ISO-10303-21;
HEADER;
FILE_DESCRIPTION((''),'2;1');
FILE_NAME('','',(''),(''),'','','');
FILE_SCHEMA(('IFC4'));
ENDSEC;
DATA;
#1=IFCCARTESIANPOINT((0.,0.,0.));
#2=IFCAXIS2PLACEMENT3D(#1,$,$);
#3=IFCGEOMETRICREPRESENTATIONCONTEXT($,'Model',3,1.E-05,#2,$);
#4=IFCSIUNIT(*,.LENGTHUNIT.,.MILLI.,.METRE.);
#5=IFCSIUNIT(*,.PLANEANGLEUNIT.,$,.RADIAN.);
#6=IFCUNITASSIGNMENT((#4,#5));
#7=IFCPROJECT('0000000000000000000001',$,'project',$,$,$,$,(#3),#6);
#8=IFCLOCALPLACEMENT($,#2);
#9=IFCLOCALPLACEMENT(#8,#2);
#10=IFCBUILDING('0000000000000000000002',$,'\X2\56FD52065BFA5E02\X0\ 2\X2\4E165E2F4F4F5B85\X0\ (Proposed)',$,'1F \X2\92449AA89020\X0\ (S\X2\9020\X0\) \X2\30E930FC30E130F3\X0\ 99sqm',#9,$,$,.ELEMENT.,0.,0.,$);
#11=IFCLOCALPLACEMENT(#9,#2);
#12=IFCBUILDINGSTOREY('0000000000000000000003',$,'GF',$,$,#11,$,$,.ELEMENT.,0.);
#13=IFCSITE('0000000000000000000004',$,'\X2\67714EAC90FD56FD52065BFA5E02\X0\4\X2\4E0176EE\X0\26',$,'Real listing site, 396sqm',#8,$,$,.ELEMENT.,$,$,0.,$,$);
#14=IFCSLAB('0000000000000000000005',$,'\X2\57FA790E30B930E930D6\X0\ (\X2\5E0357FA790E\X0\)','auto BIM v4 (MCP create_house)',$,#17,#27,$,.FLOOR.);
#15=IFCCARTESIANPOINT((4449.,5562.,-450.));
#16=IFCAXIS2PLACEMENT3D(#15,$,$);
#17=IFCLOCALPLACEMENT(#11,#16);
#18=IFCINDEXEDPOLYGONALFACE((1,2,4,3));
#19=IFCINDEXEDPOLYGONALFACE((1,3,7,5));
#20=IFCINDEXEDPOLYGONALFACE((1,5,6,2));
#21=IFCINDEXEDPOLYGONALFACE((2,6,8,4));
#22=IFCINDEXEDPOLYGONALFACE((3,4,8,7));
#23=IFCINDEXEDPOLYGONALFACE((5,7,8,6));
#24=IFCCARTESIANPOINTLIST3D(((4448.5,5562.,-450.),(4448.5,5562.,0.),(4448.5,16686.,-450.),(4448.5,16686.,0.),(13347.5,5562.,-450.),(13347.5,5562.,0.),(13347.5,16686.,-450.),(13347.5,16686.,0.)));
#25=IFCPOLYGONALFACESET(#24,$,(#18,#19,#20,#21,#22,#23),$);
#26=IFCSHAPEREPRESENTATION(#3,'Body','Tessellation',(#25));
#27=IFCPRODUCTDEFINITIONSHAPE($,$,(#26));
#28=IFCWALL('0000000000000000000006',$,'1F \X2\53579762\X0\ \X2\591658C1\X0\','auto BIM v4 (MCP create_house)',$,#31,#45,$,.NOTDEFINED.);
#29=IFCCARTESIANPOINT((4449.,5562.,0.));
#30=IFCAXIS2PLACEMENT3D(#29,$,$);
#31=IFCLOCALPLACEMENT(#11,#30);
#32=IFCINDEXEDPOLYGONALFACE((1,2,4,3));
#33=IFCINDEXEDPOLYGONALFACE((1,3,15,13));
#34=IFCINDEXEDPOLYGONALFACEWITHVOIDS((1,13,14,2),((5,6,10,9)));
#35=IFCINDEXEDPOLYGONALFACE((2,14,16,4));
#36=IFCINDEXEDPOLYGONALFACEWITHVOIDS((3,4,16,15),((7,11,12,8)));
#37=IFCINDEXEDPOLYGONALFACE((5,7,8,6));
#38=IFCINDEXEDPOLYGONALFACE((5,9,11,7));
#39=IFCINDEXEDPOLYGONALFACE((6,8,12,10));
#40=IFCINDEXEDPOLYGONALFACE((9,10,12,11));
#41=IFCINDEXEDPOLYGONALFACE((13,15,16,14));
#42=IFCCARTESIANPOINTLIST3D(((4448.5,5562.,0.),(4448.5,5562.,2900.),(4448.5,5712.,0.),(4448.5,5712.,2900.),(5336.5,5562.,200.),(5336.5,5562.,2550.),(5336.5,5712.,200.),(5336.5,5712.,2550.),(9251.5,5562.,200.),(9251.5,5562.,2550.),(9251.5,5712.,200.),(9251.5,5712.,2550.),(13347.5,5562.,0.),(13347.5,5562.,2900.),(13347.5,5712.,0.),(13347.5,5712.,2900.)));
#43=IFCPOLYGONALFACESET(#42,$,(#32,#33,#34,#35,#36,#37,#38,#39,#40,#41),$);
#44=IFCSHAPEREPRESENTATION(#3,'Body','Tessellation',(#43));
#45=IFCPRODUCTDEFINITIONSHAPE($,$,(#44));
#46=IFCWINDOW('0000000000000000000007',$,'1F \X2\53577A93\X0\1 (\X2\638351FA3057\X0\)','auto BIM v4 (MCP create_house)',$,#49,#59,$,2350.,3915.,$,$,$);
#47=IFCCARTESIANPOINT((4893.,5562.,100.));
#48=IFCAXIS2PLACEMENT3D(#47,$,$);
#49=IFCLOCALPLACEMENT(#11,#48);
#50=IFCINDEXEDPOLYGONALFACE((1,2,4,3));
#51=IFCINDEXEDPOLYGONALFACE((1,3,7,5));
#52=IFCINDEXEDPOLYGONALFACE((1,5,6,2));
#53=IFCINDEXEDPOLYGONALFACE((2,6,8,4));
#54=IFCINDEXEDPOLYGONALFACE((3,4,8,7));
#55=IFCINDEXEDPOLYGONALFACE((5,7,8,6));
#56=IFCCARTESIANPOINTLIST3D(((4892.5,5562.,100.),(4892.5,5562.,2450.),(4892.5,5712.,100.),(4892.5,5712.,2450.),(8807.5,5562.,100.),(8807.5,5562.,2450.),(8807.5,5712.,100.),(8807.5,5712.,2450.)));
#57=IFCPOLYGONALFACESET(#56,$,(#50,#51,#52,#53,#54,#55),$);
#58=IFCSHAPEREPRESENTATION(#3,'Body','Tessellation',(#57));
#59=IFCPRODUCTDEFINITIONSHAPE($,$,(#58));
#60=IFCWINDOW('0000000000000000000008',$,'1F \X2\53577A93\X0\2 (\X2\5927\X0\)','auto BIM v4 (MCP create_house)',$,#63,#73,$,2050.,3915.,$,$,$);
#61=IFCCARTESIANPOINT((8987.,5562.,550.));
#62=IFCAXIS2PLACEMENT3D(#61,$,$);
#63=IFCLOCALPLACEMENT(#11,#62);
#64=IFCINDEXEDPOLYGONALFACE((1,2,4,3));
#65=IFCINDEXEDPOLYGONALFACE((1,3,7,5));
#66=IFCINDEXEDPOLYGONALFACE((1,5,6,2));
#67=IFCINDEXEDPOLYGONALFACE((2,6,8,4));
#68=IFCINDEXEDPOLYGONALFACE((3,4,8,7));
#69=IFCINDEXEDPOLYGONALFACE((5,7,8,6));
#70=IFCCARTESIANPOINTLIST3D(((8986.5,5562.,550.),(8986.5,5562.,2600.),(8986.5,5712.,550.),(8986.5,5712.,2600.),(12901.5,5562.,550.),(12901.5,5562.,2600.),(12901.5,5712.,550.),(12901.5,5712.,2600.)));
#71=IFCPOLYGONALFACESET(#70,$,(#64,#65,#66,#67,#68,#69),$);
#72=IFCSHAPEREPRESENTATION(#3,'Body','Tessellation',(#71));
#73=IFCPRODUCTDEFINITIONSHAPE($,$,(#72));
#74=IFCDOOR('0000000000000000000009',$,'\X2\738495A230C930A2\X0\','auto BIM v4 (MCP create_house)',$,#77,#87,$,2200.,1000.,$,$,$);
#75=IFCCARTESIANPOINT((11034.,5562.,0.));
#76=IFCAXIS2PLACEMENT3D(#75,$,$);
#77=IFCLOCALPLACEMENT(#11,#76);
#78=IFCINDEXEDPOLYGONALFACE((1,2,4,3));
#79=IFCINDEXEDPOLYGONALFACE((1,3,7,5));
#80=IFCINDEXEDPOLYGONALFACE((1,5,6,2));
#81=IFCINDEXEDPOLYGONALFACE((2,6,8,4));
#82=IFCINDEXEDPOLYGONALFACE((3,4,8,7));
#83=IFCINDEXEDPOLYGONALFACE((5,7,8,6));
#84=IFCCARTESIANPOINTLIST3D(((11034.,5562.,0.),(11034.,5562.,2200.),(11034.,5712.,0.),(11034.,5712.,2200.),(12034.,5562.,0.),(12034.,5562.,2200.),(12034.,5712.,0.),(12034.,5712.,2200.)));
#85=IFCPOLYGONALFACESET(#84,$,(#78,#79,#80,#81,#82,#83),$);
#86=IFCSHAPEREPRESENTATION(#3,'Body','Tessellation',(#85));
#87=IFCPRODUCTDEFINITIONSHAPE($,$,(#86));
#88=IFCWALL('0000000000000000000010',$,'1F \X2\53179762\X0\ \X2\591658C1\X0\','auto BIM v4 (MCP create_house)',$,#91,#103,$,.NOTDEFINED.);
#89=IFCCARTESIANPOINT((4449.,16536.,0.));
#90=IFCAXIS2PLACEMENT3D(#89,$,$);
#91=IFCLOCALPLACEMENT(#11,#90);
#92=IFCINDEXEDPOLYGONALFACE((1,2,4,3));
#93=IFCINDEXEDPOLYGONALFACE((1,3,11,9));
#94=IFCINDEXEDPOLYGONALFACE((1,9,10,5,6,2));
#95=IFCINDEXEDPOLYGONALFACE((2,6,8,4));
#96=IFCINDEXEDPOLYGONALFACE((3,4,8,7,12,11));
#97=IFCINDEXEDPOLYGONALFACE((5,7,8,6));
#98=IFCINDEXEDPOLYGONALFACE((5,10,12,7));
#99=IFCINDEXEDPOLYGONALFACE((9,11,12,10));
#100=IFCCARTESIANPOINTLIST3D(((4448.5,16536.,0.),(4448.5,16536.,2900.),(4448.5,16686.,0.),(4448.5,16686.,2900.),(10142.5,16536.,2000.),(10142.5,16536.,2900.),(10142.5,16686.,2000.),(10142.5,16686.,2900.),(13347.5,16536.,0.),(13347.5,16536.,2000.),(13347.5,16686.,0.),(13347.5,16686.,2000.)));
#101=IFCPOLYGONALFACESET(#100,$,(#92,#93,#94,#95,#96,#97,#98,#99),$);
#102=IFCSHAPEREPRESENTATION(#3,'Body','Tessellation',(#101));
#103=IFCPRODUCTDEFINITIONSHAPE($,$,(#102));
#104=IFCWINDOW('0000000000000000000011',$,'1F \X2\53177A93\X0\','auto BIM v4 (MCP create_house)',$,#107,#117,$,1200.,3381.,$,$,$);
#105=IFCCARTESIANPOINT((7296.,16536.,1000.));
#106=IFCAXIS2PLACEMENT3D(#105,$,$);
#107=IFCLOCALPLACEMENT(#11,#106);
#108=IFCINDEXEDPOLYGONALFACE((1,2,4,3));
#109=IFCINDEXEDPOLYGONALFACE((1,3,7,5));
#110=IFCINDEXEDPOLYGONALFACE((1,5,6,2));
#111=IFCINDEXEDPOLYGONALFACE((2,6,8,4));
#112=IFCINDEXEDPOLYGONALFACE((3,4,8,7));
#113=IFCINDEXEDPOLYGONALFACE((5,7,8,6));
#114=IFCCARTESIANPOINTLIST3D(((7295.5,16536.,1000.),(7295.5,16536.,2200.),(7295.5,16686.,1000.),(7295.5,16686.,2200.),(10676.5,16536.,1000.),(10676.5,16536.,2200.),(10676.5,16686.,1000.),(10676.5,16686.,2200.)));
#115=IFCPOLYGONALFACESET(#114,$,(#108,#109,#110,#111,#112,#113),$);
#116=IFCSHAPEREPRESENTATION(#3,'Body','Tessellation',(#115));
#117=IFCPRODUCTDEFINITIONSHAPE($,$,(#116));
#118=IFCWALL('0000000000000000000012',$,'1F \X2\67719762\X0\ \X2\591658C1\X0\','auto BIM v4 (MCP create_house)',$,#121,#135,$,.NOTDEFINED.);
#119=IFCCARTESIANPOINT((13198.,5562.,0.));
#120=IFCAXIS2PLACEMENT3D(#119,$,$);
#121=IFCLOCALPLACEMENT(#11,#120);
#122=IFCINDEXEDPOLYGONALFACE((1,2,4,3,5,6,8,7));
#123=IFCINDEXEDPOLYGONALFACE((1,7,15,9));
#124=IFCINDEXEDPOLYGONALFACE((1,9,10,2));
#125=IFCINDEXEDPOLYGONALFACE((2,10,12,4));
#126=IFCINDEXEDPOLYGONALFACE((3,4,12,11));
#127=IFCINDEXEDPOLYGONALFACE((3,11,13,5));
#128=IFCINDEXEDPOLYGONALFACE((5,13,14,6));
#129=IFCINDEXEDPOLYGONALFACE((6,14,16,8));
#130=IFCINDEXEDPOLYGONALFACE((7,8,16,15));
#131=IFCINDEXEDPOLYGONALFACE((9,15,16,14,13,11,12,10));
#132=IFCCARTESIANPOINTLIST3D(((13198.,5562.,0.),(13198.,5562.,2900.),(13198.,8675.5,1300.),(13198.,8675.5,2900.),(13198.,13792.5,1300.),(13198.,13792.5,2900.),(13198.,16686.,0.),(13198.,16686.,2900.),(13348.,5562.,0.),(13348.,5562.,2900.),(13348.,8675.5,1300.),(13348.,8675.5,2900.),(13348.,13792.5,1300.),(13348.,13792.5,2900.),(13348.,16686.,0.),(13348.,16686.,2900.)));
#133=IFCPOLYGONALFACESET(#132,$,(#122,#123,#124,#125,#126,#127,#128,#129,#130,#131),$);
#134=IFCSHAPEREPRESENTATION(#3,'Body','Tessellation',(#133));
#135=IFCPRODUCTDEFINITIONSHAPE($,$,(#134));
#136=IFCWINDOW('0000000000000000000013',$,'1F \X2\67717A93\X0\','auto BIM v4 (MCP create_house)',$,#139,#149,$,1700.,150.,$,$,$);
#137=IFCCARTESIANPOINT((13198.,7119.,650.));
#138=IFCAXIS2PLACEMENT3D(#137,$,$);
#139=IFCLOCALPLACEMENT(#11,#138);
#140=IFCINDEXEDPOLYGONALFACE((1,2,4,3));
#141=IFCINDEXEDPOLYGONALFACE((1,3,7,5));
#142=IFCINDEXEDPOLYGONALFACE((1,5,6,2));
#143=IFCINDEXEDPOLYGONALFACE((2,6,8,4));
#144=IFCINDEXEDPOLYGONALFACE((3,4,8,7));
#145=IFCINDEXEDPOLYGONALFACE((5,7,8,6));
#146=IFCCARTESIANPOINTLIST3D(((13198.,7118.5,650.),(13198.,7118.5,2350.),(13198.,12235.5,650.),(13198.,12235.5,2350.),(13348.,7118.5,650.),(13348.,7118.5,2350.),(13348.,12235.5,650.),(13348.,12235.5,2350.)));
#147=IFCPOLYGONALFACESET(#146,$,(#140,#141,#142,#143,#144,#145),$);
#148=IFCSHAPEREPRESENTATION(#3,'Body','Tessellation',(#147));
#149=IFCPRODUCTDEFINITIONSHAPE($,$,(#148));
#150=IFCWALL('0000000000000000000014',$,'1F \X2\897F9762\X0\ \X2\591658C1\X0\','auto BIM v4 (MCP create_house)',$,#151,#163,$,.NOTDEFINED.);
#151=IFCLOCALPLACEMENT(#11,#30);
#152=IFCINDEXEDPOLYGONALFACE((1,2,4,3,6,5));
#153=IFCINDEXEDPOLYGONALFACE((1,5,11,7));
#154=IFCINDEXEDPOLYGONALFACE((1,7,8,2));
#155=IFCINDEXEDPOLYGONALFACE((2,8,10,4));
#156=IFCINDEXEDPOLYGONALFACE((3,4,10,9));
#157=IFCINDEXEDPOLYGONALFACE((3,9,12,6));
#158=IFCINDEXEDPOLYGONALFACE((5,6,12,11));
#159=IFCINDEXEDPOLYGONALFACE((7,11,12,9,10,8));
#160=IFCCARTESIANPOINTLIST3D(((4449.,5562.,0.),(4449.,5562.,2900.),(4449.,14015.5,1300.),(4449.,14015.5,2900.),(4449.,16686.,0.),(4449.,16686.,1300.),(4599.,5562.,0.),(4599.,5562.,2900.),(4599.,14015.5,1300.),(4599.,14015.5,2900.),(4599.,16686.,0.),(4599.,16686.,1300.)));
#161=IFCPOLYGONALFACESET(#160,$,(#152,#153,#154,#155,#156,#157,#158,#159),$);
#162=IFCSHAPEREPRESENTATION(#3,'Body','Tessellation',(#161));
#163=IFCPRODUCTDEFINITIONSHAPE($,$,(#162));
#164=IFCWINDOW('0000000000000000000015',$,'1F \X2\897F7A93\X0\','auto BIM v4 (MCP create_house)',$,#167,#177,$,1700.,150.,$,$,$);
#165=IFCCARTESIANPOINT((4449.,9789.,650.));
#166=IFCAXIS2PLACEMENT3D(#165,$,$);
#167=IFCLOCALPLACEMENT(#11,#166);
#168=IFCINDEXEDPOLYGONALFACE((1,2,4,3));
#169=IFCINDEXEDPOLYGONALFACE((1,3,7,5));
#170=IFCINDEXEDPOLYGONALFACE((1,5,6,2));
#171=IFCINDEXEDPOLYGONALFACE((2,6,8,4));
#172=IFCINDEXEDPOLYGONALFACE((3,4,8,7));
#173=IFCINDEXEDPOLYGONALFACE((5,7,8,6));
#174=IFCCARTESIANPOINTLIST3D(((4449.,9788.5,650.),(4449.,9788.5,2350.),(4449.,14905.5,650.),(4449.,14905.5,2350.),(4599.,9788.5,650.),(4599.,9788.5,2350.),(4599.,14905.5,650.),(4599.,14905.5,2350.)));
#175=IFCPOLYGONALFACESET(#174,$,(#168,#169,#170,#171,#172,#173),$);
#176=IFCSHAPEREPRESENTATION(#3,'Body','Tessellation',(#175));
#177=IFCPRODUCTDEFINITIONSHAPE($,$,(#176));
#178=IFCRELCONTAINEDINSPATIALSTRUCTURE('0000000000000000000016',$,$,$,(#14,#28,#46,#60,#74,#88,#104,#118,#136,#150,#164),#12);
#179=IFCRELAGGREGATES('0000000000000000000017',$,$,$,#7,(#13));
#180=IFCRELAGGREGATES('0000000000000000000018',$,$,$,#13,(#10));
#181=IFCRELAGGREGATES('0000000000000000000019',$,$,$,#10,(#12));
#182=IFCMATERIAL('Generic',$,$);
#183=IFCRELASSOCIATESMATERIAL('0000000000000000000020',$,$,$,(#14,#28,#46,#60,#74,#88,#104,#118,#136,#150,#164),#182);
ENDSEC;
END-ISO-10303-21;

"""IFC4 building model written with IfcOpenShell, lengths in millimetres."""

from ifc_helpers import new_model, si_unit, frame, frame_2d, origin, place, context, project, spatial, rectangle, extrude, material, element, fill, save


model = new_model("IFC4")

# Units and contexts
model_context = context("Model", 3, precision=1e-05, world=origin())
ifc_project = project(units=[si_unit("LENGTHUNIT", "METRE", prefix="MILLI"), si_unit("PLANEANGLEUNIT", "RADIAN")], contexts=[model_context])

# Site, building, storey
site_placement = place(None, origin())
site = spatial("IfcSite", under=ifc_project, at=site_placement, Name="東京都国分寺市4丁目26", ObjectType="Real listing site, 396sqm", CompositionType="ELEMENT", RefElevation=0.0)
building_placement = place(site_placement, origin())
building = spatial("IfcBuilding", under=site, at=building_placement, Name="国分寺市 2世帯住宅 (Proposed)", ObjectType="1F 鉄骨造 (S造) ラーメン 99sqm", CompositionType="ELEMENT", ElevationOfRefHeight=0.0, ElevationOfTerrain=0.0)
storey_placement = place(building_placement, origin())
storey = spatial("IfcBuildingStorey", under=building, at=storey_placement, Name="GF", CompositionType="ELEMENT", Elevation=0.0)

# Slab
ifc_material = material(Name="Generic")
slab_1_placement = place(storey_placement, frame((4449.0, 5562.0, -450.0)))
element("IfcSlab", 1, at=slab_1_placement, inside=storey, material=ifc_material, Name="基礎スラブ (布基礎)", Description="auto BIM v4 (MCP create_house)", PredefinedType="FLOOR", context=model_context, shape_type="SweptSolid", body=[
    extrude(rectangle(XDim=8899.0, YDim=11124.0, at=frame_2d((4449.0, 5562.0))), frame((4449.0, 5562.0, -450.0)), (0.0, 0.0, 1.0), 450.0),
])

# Wall, openings, windows, door
wall_1_placement = place(storey_placement, frame((4449.0, 5562.0, 0.0)))
wall_1 = element("IfcWall", 2, at=wall_1_placement, inside=storey, material=ifc_material, Name="1F 南面 外壁", Description="auto BIM v4 (MCP create_house)", PredefinedType="NOTDEFINED", context=model_context, shape_type="SweptSolid", body=[
    extrude(rectangle(XDim=8899.0, YDim=150.0, at=frame_2d((4449.0, 75.0))), frame((4449.0, 5562.0, 0.0)), (0.0, 0.0, 1.0), 2900.0),
])
opening_1_placement = place(storey_placement, frame((4893.0, 5562.0, 100.0)))
opening_1 = element("IfcOpeningElement", 3, at=opening_1_placement, cuts=wall_1, PredefinedType="NOTDEFINED", context=model_context, shape_type="SweptSolid", body=[
    extrude(rectangle(XDim=3915.0, YDim=150.0, at=frame_2d((1957.0, 75.0))), frame((4893.0, 5562.0, 100.0)), (0.0, 0.0, 1.0), 2350.0),
])
opening_2_placement = place(storey_placement, frame((8987.0, 5562.0, 550.0)))
opening_2 = element("IfcOpeningElement", 4, at=opening_2_placement, cuts=wall_1, PredefinedType="NOTDEFINED", context=model_context, shape_type="SweptSolid", body=[
    extrude(rectangle(XDim=3915.0, YDim=150.0, at=frame_2d((1957.0, 75.0))), frame((8987.0, 5562.0, 550.0)), (0.0, 0.0, 1.0), 2050.0),
])
opening_3_placement = place(storey_placement, frame((11034.0, 5562.0, 0.0)))
opening_3 = element("IfcOpeningElement", 5, at=opening_3_placement, cuts=wall_1, PredefinedType="NOTDEFINED", context=model_context, shape_type="SweptSolid", body=[
    extrude(rectangle(XDim=1000.0, YDim=150.0, at=frame_2d((500.0, 75.0))), frame((11034.0, 5562.0, 0.0)), (0.0, 0.0, 1.0), 2200.0),
])
window_1_placement = place(storey_placement, frame((4893.0, 5562.0, 100.0)))
window_1 = element("IfcWindow", 6, at=window_1_placement, inside=storey, material=ifc_material, Name="1F 南窓1 (掃出し)", Description="auto BIM v4 (MCP create_house)", OverallHeight=2350.0, OverallWidth=3915.0, context=model_context, shape_type="SweptSolid", body=[
    extrude(rectangle(XDim=3915.0, YDim=150.0, at=frame_2d((1957.0, 75.0))), frame((4893.0, 5562.0, 100.0)), (0.0, 0.0, 1.0), 2350.0),
])
fill(opening_1, window_1)
window_2_placement = place(storey_placement, frame((8987.0, 5562.0, 550.0)))
window_2 = element("IfcWindow", 7, at=window_2_placement, inside=storey, material=ifc_material, Name="1F 南窓2 (大)", Description="auto BIM v4 (MCP create_house)", OverallHeight=2050.0, OverallWidth=3915.0, context=model_context, shape_type="SweptSolid", body=[
    extrude(rectangle(XDim=3915.0, YDim=150.0, at=frame_2d((1957.0, 75.0))), frame((8987.0, 5562.0, 550.0)), (0.0, 0.0, 1.0), 2050.0),
])
fill(opening_2, window_2)
door_placement = place(storey_placement, frame((11034.0, 5562.0, 0.0)))
door = element("IfcDoor", 8, at=door_placement, inside=storey, material=ifc_material, Name="玄関ドア", Description="auto BIM v4 (MCP create_house)", OverallHeight=2200.0, OverallWidth=1000.0, context=model_context, shape_type="SweptSolid", body=[
    extrude(rectangle(XDim=1000.0, YDim=150.0, at=frame_2d((500.0, 75.0))), frame((11034.0, 5562.0, 0.0)), (0.0, 0.0, 1.0), 2200.0),
])
fill(opening_3, door)

# Walls, openings, windows
wall_2_placement = place(storey_placement, frame((4449.0, 16536.0, 0.0)))
wall_2 = element("IfcWall", 9, at=wall_2_placement, inside=storey, material=ifc_material, Name="1F 北面 外壁", Description="auto BIM v4 (MCP create_house)", PredefinedType="NOTDEFINED", context=model_context, shape_type="SweptSolid", body=[
    extrude(rectangle(XDim=8899.0, YDim=150.0, at=frame_2d((4449.0, 75.0))), frame((4449.0, 16536.0, 0.0)), (0.0, 0.0, 1.0), 2900.0),
])
opening_4_placement = place(storey_placement, frame((7296.0, 16536.0, 1000.0)))
opening_4 = element("IfcOpeningElement", 10, at=opening_4_placement, cuts=wall_2, PredefinedType="NOTDEFINED", context=model_context, shape_type="SweptSolid", body=[
    extrude(rectangle(XDim=3381.0, YDim=150.0, at=frame_2d((1690.0, 75.0))), frame((7296.0, 16536.0, 1000.0)), (0.0, 0.0, 1.0), 1200.0),
])
window_3_placement = place(storey_placement, frame((7296.0, 16536.0, 1000.0)))
window_3 = element("IfcWindow", 11, at=window_3_placement, inside=storey, material=ifc_material, Name="1F 北窓", Description="auto BIM v4 (MCP create_house)", OverallHeight=1200.0, OverallWidth=3381.0, context=model_context, shape_type="SweptSolid", body=[
    extrude(rectangle(XDim=3381.0, YDim=150.0, at=frame_2d((1690.0, 75.0))), frame((7296.0, 16536.0, 1000.0)), (0.0, 0.0, 1.0), 1200.0),
])
fill(opening_4, window_3)
wall_3_placement = place(storey_placement, frame((13198.0, 5562.0, 0.0)))
wall_3 = element("IfcWall", 12, at=wall_3_placement, inside=storey, material=ifc_material, Name="1F 東面 外壁", Description="auto BIM v4 (MCP create_house)", PredefinedType="NOTDEFINED", context=model_context, shape_type="SweptSolid", body=[
    extrude(rectangle(XDim=150.0, YDim=11124.0, at=frame_2d((75.0, 5562.0))), frame((13198.0, 5562.0, 0.0)), (0.0, 0.0, 1.0), 2900.0),
])
opening_5_placement = place(storey_placement, frame((13198.0, 7119.0, 650.0)))
opening_5 = element("IfcOpeningElement", 13, at=opening_5_placement, cuts=wall_3, PredefinedType="NOTDEFINED", context=model_context, shape_type="SweptSolid", body=[
    extrude(rectangle(XDim=150.0, YDim=5117.0, at=frame_2d((75.0, 2558.0))), frame((13198.0, 7119.0, 650.0)), (0.0, 0.0, 1.0), 1700.0),
])
window_4_placement = place(storey_placement, frame((13198.0, 7119.0, 650.0)))
window_4 = element("IfcWindow", 14, at=window_4_placement, inside=storey, material=ifc_material, Name="1F 東窓", Description="auto BIM v4 (MCP create_house)", OverallHeight=1700.0, OverallWidth=150.0, context=model_context, shape_type="SweptSolid", body=[
    extrude(rectangle(XDim=150.0, YDim=5117.0, at=frame_2d((75.0, 2558.0))), frame((13198.0, 7119.0, 650.0)), (0.0, 0.0, 1.0), 1700.0),
])
fill(opening_5, window_4)
wall_4_placement = place(storey_placement, frame((4449.0, 5562.0, 0.0)))
wall_4 = element("IfcWall", 15, at=wall_4_placement, inside=storey, material=ifc_material, Name="1F 西面 外壁", Description="auto BIM v4 (MCP create_house)", PredefinedType="NOTDEFINED", context=model_context, shape_type="SweptSolid", body=[
    extrude(rectangle(XDim=150.0, YDim=11124.0, at=frame_2d((75.0, 5562.0))), frame((4449.0, 5562.0, 0.0)), (0.0, 0.0, 1.0), 2900.0),
])
opening_6_placement = place(storey_placement, frame((4449.0, 9789.0, 650.0)))
opening_6 = element("IfcOpeningElement", 16, at=opening_6_placement, cuts=wall_4, PredefinedType="NOTDEFINED", context=model_context, shape_type="SweptSolid", body=[
    extrude(rectangle(XDim=150.0, YDim=5117.0, at=frame_2d((75.0, 2558.0))), frame((4449.0, 9789.0, 650.0)), (0.0, 0.0, 1.0), 1700.0),
])
window_5_placement = place(storey_placement, frame((4449.0, 9789.0, 650.0)))
window_5 = element("IfcWindow", 17, at=window_5_placement, inside=storey, material=ifc_material, Name="1F 西窓", Description="auto BIM v4 (MCP create_house)", OverallHeight=1700.0, OverallWidth=150.0, context=model_context, shape_type="SweptSolid", body=[
    extrude(rectangle(XDim=150.0, YDim=5117.0, at=frame_2d((75.0, 2558.0))), frame((4449.0, 9789.0, 650.0)), (0.0, 0.0, 1.0), 1700.0),
])
fill(opening_6, window_5)

save(model, "model.ifc")
